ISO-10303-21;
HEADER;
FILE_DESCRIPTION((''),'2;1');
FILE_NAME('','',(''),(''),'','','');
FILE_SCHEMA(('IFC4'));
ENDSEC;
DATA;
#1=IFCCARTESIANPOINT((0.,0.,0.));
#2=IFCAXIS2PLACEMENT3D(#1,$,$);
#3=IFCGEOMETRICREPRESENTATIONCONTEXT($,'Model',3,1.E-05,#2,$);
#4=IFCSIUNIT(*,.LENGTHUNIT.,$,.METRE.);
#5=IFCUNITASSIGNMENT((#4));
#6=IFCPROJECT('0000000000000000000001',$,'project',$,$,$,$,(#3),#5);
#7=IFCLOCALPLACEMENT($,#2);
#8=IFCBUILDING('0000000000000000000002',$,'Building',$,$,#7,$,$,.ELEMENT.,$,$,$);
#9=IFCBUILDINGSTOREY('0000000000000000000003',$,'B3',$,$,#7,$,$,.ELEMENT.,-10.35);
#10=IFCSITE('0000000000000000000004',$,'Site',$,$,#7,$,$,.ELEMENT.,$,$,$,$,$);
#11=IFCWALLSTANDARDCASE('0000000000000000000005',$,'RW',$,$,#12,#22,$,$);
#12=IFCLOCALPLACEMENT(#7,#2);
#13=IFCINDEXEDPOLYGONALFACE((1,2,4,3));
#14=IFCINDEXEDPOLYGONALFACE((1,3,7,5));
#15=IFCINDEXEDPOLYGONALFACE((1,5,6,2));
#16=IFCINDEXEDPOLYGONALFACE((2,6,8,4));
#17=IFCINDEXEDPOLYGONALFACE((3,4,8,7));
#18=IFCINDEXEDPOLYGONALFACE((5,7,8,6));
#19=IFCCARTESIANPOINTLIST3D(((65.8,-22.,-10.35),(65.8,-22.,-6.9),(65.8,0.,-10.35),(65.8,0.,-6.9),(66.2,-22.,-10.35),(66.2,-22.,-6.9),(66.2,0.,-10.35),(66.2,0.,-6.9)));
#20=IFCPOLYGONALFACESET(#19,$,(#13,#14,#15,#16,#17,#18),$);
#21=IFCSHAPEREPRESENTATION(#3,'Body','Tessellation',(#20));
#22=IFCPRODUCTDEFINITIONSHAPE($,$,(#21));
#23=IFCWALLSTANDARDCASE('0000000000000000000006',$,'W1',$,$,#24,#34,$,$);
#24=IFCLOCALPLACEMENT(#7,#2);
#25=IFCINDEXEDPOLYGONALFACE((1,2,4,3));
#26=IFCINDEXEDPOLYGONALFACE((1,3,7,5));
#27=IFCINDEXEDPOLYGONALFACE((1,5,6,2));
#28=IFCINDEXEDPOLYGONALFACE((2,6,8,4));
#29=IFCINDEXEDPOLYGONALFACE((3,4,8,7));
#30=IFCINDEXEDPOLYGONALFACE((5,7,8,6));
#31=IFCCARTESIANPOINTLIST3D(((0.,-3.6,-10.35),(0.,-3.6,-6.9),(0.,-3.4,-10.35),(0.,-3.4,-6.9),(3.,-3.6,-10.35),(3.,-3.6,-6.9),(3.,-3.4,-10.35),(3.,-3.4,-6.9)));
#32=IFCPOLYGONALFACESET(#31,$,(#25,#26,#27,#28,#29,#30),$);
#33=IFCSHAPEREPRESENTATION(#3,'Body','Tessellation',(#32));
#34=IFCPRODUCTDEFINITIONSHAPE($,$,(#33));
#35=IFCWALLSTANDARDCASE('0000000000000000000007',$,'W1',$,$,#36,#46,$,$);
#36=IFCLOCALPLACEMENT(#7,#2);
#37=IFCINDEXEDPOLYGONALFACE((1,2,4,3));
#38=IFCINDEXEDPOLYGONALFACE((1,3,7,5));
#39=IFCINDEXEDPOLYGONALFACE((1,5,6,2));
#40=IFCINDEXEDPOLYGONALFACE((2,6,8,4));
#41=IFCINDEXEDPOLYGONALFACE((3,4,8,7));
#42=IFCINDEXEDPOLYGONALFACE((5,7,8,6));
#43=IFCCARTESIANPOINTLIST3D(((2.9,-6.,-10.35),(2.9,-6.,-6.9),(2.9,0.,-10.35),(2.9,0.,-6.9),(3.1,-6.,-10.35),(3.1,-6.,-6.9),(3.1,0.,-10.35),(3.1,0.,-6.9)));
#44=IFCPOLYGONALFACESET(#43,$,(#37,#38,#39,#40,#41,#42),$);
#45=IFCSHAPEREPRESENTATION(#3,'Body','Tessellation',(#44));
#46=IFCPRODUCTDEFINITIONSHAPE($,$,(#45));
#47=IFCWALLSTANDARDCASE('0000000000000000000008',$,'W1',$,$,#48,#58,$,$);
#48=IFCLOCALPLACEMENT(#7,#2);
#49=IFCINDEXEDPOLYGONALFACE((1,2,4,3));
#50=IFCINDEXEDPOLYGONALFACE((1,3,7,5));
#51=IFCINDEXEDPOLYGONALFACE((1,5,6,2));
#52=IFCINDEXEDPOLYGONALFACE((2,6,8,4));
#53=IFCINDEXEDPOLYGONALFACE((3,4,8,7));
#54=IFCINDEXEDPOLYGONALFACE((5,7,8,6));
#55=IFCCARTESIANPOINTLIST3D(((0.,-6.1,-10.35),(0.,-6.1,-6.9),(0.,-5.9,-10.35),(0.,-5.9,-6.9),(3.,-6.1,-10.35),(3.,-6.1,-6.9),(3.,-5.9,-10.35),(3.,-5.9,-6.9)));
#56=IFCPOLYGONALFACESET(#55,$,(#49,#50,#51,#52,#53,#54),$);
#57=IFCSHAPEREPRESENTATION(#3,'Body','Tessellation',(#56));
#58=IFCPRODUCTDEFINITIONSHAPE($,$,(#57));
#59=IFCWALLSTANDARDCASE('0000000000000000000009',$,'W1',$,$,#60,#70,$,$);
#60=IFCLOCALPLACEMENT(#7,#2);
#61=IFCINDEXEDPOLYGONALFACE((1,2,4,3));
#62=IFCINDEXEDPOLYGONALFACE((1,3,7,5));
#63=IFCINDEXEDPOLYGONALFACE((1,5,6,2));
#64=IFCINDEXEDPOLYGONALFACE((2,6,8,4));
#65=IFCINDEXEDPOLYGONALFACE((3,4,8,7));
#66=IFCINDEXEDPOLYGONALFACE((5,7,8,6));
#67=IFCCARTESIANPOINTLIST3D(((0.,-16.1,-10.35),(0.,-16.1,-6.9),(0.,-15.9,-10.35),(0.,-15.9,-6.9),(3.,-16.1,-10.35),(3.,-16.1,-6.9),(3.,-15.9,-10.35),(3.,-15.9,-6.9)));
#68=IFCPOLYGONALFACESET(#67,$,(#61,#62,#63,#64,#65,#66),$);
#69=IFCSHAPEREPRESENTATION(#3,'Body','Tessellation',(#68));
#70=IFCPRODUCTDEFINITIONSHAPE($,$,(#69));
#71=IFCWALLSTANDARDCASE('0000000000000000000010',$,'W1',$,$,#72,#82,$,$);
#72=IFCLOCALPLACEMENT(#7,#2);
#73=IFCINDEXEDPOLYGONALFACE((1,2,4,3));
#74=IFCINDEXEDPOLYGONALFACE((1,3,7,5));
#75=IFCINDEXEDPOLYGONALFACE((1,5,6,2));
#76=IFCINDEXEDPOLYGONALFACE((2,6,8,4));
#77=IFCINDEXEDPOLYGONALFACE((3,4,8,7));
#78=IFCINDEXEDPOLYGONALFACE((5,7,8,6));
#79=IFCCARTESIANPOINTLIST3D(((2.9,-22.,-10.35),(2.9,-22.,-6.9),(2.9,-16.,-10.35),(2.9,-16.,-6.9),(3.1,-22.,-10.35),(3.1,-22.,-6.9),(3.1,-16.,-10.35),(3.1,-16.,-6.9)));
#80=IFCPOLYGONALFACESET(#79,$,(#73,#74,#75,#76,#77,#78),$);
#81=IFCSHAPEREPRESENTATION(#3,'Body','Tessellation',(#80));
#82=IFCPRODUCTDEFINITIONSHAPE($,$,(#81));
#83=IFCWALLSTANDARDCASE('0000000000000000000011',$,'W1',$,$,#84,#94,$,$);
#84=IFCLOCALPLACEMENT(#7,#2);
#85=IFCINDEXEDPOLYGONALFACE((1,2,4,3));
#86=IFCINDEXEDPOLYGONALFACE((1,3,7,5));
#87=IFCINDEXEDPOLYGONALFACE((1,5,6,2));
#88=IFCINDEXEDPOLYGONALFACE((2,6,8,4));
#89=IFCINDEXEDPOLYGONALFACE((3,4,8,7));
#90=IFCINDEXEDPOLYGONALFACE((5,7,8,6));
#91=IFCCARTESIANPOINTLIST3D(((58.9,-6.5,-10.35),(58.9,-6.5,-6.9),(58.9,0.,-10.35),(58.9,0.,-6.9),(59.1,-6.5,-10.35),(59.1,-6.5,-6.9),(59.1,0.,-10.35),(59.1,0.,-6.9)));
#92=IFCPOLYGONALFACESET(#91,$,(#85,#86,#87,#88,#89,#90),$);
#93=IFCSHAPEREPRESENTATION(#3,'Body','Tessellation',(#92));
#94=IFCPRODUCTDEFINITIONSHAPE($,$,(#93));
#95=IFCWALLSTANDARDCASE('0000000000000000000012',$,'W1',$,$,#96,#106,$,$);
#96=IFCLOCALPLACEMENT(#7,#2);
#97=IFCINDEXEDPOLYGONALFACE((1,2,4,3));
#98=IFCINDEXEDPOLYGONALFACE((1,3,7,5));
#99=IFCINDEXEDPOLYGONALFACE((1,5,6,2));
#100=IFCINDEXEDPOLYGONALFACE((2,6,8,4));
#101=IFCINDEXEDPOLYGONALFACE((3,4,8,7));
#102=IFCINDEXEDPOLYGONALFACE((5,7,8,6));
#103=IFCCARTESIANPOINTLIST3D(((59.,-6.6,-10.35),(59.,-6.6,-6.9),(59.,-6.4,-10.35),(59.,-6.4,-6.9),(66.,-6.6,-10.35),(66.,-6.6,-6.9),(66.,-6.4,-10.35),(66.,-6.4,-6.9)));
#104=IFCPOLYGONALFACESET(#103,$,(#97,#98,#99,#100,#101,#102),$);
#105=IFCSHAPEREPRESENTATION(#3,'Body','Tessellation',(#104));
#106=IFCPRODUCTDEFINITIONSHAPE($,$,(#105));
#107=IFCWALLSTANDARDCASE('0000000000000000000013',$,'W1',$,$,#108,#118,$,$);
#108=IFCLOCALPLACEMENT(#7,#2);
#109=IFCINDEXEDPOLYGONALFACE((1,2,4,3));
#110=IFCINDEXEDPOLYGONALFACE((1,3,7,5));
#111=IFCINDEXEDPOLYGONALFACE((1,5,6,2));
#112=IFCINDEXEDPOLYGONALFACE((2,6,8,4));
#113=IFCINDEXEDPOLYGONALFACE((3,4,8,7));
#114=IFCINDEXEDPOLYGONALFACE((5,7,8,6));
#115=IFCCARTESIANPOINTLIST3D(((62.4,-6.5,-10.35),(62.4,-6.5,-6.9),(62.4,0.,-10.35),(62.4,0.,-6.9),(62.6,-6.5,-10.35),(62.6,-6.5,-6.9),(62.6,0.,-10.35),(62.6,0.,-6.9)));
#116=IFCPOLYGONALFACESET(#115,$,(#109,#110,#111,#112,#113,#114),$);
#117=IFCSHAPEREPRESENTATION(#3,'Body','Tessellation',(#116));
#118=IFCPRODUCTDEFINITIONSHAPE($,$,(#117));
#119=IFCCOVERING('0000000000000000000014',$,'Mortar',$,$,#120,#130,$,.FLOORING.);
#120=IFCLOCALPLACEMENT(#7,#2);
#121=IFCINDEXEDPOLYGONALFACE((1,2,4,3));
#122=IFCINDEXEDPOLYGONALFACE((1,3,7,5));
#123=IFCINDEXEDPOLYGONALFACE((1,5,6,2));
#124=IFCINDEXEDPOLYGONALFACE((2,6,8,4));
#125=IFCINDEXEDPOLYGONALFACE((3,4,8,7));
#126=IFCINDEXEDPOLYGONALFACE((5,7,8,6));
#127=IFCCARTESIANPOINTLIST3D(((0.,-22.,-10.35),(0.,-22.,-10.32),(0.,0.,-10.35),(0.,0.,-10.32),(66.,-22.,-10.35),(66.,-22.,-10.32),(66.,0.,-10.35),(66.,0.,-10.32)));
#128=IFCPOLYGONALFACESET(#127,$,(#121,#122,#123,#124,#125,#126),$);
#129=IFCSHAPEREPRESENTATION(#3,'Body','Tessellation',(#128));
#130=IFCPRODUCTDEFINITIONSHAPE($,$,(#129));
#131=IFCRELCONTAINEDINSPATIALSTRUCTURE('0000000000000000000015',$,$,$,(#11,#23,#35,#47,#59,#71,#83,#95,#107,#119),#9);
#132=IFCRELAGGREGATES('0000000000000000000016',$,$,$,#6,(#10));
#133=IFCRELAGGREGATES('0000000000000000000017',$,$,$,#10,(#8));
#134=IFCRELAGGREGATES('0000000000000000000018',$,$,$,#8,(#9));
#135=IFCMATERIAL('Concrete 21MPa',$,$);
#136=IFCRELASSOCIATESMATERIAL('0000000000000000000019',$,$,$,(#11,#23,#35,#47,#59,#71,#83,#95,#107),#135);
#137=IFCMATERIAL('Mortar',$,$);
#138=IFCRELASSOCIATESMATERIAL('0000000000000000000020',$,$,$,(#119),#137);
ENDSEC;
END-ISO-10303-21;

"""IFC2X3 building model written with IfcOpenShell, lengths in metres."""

from ifc_helpers import new_model, si_unit, frame, origin, origin_2d, place, context, project, spatial, rectangle, extrude, material, element, save


model = new_model("IFC2X3")

# Units and contexts
model_context = context("Model", 3, precision=1e-05, world=origin())
ifc_project = project(units=[si_unit("LENGTHUNIT", "METRE")], contexts=[model_context])

# Site, building, storey
placement = place(None, origin())
site = spatial("IfcSite", under=ifc_project, at=placement, Name="Site", CompositionType="ELEMENT")
building = spatial("IfcBuilding", under=site, at=placement, Name="Building", CompositionType="ELEMENT")
storey = spatial("IfcBuildingStorey", under=building, at=placement, Name="B3", CompositionType="ELEMENT", Elevation=-10.35)

# Shared definitions
ifc_material_1 = material(Name="Concrete 21MPa")

# Walls
for number, where, name in (
    (1, (66.0, -11.0, -10.35), "RW"),
):
    element("IfcWallStandardCase", number, at=place(None, frame(where)), inside=storey, material=ifc_material_1, Name=name, context=model_context, shape_type="SweptSolid", body=[
        extrude(rectangle(XDim=0.4, YDim=22.0, at=origin_2d()), origin(), (0.0, 0.0, 1.0), 3.45),
    ])
wall_1_placement = place(None, frame((1.5, -3.5, -10.35)))
element("IfcWallStandardCase", 2, at=wall_1_placement, inside=storey, material=ifc_material_1, Name="W1", context=model_context, shape_type="SweptSolid", body=[
    extrude(rectangle(XDim=3.0, YDim=0.2, at=origin_2d()), origin(), (0.0, 0.0, 1.0), 3.45),
])
wall_2_placement = place(None, frame((3.0, -3.0, -10.35)))
element("IfcWallStandardCase", 3, at=wall_2_placement, inside=storey, material=ifc_material_1, Name="W1", context=model_context, shape_type="SweptSolid", body=[
    extrude(rectangle(XDim=0.2, YDim=6.0, at=origin_2d()), origin(), (0.0, 0.0, 1.0), 3.45),
])
for number, where, name in (
    (4, (1.5, -6.0, -10.35), "W1"),
    (5, (1.5, -16.0, -10.35), "W1"),
):
    element("IfcWallStandardCase", number, at=place(None, frame(where)), inside=storey, material=ifc_material_1, Name=name, context=model_context, shape_type="SweptSolid", body=[
        extrude(rectangle(XDim=3.0, YDim=0.2, at=origin_2d()), origin(), (0.0, 0.0, 1.0), 3.45),
    ])
wall_3_placement = place(None, frame((3.0, -19.0, -10.35)))
element("IfcWallStandardCase", 6, at=wall_3_placement, inside=storey, material=ifc_material_1, Name="W1", context=model_context, shape_type="SweptSolid", body=[
    extrude(rectangle(XDim=0.2, YDim=6.0, at=origin_2d()), origin(), (0.0, 0.0, 1.0), 3.45),
])
wall_4_placement = place(None, frame((59.0, -3.25, -10.35)))
element("IfcWallStandardCase", 7, at=wall_4_placement, inside=storey, material=ifc_material_1, Name="W1", context=model_context, shape_type="SweptSolid", body=[
    extrude(rectangle(XDim=0.2, YDim=6.5, at=origin_2d()), origin(), (0.0, 0.0, 1.0), 3.45),
])
wall_5_placement = place(None, frame((62.5, -6.5, -10.35)))
element("IfcWallStandardCase", 8, at=wall_5_placement, inside=storey, material=ifc_material_1, Name="W1", context=model_context, shape_type="SweptSolid", body=[
    extrude(rectangle(XDim=7.0, YDim=0.2, at=origin_2d()), origin(), (0.0, 0.0, 1.0), 3.45),
])
wall_6_placement = place(None, frame((62.5, -3.25, -10.35)))
element("IfcWallStandardCase", 9, at=wall_6_placement, inside=storey, material=ifc_material_1, Name="W1", context=model_context, shape_type="SweptSolid", body=[
    extrude(rectangle(XDim=0.2, YDim=6.5, at=origin_2d()), origin(), (0.0, 0.0, 1.0), 3.45),
])

# Covering
ifc_material_2 = material(Name="Mortar")
covering_placement = place(None, frame((33.0, -11.0, -10.35)))
element("IfcCovering", 10, at=covering_placement, inside=storey, material=ifc_material_2, Name="Mortar", PredefinedType="FLOORING", context=model_context, shape_type="SweptSolid", body=[
    extrude(rectangle(XDim=66.0, YDim=22.0, at=origin_2d()), origin(), (0.0, 0.0, 1.0), 0.03),
])

save(model, "model.ifc")
